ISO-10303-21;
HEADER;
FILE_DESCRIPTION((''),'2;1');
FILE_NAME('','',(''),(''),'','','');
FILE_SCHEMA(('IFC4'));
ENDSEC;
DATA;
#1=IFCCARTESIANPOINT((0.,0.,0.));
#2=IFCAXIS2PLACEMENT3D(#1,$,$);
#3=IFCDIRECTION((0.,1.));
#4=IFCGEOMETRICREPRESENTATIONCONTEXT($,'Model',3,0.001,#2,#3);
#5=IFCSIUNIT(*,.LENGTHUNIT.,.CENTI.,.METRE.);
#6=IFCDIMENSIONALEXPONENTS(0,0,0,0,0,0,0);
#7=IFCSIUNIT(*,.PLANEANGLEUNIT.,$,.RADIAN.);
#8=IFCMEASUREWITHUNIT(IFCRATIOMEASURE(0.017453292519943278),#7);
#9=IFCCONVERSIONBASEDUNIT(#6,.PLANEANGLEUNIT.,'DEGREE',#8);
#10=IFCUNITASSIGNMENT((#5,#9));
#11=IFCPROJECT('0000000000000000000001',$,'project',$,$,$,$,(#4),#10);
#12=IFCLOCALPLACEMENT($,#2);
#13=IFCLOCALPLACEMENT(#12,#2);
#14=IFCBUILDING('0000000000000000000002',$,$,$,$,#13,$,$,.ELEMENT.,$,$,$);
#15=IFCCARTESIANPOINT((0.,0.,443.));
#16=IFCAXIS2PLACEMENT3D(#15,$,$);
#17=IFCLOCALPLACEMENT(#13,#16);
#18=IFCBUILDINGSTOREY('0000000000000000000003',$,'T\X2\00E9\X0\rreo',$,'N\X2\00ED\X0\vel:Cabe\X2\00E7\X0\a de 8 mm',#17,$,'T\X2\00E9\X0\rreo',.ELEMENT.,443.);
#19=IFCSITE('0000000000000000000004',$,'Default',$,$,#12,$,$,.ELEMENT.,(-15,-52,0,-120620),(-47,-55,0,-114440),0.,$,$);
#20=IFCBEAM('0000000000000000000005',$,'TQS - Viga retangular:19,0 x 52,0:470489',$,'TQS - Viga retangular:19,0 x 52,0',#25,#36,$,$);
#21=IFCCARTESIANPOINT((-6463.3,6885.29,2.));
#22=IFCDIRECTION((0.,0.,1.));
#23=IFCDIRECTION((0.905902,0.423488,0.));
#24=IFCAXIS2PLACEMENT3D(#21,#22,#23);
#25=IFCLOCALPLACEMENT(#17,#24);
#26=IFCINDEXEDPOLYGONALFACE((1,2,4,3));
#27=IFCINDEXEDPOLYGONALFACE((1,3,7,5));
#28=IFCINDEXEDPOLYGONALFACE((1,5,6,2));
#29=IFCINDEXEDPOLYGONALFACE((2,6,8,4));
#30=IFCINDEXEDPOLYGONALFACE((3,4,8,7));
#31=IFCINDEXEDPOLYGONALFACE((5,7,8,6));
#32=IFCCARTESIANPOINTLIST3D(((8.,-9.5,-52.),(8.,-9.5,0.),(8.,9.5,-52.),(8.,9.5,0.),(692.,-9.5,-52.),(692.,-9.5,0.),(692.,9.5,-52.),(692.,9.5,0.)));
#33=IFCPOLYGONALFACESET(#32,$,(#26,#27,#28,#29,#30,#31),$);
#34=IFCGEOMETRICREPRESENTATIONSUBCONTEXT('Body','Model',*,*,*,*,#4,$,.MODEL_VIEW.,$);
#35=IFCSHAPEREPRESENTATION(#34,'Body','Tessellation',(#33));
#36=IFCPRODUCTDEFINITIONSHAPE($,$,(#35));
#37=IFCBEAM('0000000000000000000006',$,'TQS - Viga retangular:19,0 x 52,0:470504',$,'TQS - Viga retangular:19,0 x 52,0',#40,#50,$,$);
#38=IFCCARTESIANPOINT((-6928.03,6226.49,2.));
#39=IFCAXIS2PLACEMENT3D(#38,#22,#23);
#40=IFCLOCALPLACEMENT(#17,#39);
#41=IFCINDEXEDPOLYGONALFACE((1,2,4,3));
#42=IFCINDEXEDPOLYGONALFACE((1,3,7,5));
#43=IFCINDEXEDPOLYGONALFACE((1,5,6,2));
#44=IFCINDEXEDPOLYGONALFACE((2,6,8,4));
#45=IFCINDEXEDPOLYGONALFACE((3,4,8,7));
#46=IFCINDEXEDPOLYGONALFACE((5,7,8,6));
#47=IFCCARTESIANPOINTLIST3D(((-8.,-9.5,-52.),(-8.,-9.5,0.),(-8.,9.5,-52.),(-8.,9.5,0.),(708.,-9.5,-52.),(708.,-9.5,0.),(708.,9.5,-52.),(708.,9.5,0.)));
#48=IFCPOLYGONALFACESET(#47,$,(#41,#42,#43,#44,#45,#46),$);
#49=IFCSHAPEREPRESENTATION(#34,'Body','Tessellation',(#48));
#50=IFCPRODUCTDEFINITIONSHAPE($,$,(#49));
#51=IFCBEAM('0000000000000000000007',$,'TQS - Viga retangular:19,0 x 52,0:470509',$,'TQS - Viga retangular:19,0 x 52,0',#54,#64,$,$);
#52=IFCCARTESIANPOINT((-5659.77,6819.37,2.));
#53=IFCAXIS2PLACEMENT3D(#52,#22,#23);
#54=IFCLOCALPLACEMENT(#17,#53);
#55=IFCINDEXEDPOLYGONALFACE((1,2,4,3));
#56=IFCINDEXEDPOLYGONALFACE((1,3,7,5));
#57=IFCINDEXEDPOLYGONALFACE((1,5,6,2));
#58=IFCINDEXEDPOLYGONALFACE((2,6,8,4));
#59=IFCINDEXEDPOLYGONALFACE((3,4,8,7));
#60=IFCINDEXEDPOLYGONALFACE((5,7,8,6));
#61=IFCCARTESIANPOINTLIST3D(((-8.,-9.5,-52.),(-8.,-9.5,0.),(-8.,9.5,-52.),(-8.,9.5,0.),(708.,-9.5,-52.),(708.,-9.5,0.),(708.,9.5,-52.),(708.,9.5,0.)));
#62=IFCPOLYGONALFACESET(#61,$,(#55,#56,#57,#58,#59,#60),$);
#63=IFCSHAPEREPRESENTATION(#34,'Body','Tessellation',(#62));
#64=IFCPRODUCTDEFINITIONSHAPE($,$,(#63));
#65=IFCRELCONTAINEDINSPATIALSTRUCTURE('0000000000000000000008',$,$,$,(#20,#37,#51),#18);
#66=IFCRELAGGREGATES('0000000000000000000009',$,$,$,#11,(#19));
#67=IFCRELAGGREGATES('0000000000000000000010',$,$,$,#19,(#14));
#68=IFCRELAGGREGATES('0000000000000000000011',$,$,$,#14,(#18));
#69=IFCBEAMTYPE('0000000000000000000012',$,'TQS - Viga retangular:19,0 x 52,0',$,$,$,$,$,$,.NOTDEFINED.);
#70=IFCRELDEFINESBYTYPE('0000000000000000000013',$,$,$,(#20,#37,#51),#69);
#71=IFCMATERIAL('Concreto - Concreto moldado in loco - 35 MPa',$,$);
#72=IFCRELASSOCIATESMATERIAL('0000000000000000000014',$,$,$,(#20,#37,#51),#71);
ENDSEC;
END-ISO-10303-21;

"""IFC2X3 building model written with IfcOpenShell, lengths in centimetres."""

from ifc_helpers import new_model, entity, si_unit, converted_unit, direction, frame, frame_2d, origin, place, context, subcontext, project, spatial, rectangle, extrude, material, type_object, element, save


model = new_model("IFC2X3")

# Units and contexts
model_context = context("Model", 3, precision=0.001, world=origin(), true_north=direction((0.0, 1.0)))
body_context = subcontext(model_context, "Body", "Model", "MODEL_VIEW")
ifc_project = project(units=[si_unit("LENGTHUNIT", "METRE", prefix="CENTI"), converted_unit("PLANEANGLEUNIT", "DEGREE", entity("IfcRatioMeasure", 0.017453292519943278), si_unit("PLANEANGLEUNIT", "RADIAN"), dimensions=[0, 0, 0, 0, 0, 0, 0])], contexts=[model_context])

# Site, building, storey
site_placement = place(None, origin())
site = spatial("IfcSite", under=ifc_project, at=site_placement, Name="Default", CompositionType="ELEMENT", RefLatitude=(-15, -52, 0, -120620), RefLongitude=(-47, -55, 0, -114440), RefElevation=0.0)
building_placement = place(site_placement, origin())
building = spatial("IfcBuilding", under=site, at=building_placement, CompositionType="ELEMENT")
storey_placement = place(building_placement, frame((0.0, 0.0, 443.0)))
storey = spatial("IfcBuildingStorey", under=building, at=storey_placement, Name="Térreo", ObjectType="Nível:Cabeça de 8 mm", LongName="Térreo", CompositionType="ELEMENT", Elevation=443.0)

# Shared definitions
ifc_material_1 = material(Name="Concreto - Concreto moldado in loco - 35 MPa")

# Beams
beam_type_1 = type_object("IfcBeamType", Name="TQS - Viga retangular:19,0 x 52,0", PredefinedType="NOTDEFINED")
beam_1_placement = place(storey_placement, frame((-6463.3, 6885.29, 2.0), z_axis=(0.0, 0.0, 1.0), x_axis=(0.905902, 0.423488, 0.0)))
element("IfcBeam", 1, at=beam_1_placement, inside=storey, type_object=beam_type_1, material=ifc_material_1, Name="TQS - Viga retangular:19,0 x 52,0:470489", ObjectType="TQS - Viga retangular:19,0 x 52,0", context=body_context, shape_type="SweptSolid", body=[
    extrude(rectangle(XDim=52.0, YDim=19.0, at=frame_2d((0.0, 0.0), x_axis=(1.0, 0.0))), frame((8.0, 0.0, -26.0), z_axis=(1.0, 0.0, 0.0), x_axis=(0.0, 0.0, -1.0)), (0.0, 0.0, 1.0), 684.0),
])
beam_2_placement = place(storey_placement, frame((-6928.03, 6226.49, 2.0), z_axis=(0.0, 0.0, 1.0), x_axis=(0.905902, 0.423488, 0.0)))
element("IfcBeam", 2, at=beam_2_placement, inside=storey, type_object=beam_type_1, material=ifc_material_1, Name="TQS - Viga retangular:19,0 x 52,0:470504", ObjectType="TQS - Viga retangular:19,0 x 52,0", context=body_context, shape_type="SweptSolid", body=[
    extrude(rectangle(XDim=52.0, YDim=19.0, at=frame_2d((0.0, 0.0), x_axis=(1.0, 0.0))), frame((-8.0, 0.0, -26.0), z_axis=(1.0, 0.0, 0.0), x_axis=(0.0, 0.0, -1.0)), (0.0, 0.0, 1.0), 716.0),
])
beam_3_placement = place(storey_placement, frame((-5659.77, 6819.37, 2.0), z_axis=(0.0, 0.0, 1.0), x_axis=(0.905902, 0.423488, 0.0)))
element("IfcBeam", 3, at=beam_3_placement, inside=storey, type_object=beam_type_1, material=ifc_material_1, Name="TQS - Viga retangular:19,0 x 52,0:470509", ObjectType="TQS - Viga retangular:19,0 x 52,0", context=body_context, shape_type="SweptSolid", body=[
    extrude(rectangle(XDim=52.0, YDim=19.0, at=frame_2d((0.0, 0.0), x_axis=(1.0, 0.0))), frame((-8.0, 0.0, -26.0), z_axis=(1.0, 0.0, 0.0), x_axis=(0.0, 0.0, -1.0)), (0.0, 0.0, 1.0), 716.0),
])

save(model, "model.ifc")
